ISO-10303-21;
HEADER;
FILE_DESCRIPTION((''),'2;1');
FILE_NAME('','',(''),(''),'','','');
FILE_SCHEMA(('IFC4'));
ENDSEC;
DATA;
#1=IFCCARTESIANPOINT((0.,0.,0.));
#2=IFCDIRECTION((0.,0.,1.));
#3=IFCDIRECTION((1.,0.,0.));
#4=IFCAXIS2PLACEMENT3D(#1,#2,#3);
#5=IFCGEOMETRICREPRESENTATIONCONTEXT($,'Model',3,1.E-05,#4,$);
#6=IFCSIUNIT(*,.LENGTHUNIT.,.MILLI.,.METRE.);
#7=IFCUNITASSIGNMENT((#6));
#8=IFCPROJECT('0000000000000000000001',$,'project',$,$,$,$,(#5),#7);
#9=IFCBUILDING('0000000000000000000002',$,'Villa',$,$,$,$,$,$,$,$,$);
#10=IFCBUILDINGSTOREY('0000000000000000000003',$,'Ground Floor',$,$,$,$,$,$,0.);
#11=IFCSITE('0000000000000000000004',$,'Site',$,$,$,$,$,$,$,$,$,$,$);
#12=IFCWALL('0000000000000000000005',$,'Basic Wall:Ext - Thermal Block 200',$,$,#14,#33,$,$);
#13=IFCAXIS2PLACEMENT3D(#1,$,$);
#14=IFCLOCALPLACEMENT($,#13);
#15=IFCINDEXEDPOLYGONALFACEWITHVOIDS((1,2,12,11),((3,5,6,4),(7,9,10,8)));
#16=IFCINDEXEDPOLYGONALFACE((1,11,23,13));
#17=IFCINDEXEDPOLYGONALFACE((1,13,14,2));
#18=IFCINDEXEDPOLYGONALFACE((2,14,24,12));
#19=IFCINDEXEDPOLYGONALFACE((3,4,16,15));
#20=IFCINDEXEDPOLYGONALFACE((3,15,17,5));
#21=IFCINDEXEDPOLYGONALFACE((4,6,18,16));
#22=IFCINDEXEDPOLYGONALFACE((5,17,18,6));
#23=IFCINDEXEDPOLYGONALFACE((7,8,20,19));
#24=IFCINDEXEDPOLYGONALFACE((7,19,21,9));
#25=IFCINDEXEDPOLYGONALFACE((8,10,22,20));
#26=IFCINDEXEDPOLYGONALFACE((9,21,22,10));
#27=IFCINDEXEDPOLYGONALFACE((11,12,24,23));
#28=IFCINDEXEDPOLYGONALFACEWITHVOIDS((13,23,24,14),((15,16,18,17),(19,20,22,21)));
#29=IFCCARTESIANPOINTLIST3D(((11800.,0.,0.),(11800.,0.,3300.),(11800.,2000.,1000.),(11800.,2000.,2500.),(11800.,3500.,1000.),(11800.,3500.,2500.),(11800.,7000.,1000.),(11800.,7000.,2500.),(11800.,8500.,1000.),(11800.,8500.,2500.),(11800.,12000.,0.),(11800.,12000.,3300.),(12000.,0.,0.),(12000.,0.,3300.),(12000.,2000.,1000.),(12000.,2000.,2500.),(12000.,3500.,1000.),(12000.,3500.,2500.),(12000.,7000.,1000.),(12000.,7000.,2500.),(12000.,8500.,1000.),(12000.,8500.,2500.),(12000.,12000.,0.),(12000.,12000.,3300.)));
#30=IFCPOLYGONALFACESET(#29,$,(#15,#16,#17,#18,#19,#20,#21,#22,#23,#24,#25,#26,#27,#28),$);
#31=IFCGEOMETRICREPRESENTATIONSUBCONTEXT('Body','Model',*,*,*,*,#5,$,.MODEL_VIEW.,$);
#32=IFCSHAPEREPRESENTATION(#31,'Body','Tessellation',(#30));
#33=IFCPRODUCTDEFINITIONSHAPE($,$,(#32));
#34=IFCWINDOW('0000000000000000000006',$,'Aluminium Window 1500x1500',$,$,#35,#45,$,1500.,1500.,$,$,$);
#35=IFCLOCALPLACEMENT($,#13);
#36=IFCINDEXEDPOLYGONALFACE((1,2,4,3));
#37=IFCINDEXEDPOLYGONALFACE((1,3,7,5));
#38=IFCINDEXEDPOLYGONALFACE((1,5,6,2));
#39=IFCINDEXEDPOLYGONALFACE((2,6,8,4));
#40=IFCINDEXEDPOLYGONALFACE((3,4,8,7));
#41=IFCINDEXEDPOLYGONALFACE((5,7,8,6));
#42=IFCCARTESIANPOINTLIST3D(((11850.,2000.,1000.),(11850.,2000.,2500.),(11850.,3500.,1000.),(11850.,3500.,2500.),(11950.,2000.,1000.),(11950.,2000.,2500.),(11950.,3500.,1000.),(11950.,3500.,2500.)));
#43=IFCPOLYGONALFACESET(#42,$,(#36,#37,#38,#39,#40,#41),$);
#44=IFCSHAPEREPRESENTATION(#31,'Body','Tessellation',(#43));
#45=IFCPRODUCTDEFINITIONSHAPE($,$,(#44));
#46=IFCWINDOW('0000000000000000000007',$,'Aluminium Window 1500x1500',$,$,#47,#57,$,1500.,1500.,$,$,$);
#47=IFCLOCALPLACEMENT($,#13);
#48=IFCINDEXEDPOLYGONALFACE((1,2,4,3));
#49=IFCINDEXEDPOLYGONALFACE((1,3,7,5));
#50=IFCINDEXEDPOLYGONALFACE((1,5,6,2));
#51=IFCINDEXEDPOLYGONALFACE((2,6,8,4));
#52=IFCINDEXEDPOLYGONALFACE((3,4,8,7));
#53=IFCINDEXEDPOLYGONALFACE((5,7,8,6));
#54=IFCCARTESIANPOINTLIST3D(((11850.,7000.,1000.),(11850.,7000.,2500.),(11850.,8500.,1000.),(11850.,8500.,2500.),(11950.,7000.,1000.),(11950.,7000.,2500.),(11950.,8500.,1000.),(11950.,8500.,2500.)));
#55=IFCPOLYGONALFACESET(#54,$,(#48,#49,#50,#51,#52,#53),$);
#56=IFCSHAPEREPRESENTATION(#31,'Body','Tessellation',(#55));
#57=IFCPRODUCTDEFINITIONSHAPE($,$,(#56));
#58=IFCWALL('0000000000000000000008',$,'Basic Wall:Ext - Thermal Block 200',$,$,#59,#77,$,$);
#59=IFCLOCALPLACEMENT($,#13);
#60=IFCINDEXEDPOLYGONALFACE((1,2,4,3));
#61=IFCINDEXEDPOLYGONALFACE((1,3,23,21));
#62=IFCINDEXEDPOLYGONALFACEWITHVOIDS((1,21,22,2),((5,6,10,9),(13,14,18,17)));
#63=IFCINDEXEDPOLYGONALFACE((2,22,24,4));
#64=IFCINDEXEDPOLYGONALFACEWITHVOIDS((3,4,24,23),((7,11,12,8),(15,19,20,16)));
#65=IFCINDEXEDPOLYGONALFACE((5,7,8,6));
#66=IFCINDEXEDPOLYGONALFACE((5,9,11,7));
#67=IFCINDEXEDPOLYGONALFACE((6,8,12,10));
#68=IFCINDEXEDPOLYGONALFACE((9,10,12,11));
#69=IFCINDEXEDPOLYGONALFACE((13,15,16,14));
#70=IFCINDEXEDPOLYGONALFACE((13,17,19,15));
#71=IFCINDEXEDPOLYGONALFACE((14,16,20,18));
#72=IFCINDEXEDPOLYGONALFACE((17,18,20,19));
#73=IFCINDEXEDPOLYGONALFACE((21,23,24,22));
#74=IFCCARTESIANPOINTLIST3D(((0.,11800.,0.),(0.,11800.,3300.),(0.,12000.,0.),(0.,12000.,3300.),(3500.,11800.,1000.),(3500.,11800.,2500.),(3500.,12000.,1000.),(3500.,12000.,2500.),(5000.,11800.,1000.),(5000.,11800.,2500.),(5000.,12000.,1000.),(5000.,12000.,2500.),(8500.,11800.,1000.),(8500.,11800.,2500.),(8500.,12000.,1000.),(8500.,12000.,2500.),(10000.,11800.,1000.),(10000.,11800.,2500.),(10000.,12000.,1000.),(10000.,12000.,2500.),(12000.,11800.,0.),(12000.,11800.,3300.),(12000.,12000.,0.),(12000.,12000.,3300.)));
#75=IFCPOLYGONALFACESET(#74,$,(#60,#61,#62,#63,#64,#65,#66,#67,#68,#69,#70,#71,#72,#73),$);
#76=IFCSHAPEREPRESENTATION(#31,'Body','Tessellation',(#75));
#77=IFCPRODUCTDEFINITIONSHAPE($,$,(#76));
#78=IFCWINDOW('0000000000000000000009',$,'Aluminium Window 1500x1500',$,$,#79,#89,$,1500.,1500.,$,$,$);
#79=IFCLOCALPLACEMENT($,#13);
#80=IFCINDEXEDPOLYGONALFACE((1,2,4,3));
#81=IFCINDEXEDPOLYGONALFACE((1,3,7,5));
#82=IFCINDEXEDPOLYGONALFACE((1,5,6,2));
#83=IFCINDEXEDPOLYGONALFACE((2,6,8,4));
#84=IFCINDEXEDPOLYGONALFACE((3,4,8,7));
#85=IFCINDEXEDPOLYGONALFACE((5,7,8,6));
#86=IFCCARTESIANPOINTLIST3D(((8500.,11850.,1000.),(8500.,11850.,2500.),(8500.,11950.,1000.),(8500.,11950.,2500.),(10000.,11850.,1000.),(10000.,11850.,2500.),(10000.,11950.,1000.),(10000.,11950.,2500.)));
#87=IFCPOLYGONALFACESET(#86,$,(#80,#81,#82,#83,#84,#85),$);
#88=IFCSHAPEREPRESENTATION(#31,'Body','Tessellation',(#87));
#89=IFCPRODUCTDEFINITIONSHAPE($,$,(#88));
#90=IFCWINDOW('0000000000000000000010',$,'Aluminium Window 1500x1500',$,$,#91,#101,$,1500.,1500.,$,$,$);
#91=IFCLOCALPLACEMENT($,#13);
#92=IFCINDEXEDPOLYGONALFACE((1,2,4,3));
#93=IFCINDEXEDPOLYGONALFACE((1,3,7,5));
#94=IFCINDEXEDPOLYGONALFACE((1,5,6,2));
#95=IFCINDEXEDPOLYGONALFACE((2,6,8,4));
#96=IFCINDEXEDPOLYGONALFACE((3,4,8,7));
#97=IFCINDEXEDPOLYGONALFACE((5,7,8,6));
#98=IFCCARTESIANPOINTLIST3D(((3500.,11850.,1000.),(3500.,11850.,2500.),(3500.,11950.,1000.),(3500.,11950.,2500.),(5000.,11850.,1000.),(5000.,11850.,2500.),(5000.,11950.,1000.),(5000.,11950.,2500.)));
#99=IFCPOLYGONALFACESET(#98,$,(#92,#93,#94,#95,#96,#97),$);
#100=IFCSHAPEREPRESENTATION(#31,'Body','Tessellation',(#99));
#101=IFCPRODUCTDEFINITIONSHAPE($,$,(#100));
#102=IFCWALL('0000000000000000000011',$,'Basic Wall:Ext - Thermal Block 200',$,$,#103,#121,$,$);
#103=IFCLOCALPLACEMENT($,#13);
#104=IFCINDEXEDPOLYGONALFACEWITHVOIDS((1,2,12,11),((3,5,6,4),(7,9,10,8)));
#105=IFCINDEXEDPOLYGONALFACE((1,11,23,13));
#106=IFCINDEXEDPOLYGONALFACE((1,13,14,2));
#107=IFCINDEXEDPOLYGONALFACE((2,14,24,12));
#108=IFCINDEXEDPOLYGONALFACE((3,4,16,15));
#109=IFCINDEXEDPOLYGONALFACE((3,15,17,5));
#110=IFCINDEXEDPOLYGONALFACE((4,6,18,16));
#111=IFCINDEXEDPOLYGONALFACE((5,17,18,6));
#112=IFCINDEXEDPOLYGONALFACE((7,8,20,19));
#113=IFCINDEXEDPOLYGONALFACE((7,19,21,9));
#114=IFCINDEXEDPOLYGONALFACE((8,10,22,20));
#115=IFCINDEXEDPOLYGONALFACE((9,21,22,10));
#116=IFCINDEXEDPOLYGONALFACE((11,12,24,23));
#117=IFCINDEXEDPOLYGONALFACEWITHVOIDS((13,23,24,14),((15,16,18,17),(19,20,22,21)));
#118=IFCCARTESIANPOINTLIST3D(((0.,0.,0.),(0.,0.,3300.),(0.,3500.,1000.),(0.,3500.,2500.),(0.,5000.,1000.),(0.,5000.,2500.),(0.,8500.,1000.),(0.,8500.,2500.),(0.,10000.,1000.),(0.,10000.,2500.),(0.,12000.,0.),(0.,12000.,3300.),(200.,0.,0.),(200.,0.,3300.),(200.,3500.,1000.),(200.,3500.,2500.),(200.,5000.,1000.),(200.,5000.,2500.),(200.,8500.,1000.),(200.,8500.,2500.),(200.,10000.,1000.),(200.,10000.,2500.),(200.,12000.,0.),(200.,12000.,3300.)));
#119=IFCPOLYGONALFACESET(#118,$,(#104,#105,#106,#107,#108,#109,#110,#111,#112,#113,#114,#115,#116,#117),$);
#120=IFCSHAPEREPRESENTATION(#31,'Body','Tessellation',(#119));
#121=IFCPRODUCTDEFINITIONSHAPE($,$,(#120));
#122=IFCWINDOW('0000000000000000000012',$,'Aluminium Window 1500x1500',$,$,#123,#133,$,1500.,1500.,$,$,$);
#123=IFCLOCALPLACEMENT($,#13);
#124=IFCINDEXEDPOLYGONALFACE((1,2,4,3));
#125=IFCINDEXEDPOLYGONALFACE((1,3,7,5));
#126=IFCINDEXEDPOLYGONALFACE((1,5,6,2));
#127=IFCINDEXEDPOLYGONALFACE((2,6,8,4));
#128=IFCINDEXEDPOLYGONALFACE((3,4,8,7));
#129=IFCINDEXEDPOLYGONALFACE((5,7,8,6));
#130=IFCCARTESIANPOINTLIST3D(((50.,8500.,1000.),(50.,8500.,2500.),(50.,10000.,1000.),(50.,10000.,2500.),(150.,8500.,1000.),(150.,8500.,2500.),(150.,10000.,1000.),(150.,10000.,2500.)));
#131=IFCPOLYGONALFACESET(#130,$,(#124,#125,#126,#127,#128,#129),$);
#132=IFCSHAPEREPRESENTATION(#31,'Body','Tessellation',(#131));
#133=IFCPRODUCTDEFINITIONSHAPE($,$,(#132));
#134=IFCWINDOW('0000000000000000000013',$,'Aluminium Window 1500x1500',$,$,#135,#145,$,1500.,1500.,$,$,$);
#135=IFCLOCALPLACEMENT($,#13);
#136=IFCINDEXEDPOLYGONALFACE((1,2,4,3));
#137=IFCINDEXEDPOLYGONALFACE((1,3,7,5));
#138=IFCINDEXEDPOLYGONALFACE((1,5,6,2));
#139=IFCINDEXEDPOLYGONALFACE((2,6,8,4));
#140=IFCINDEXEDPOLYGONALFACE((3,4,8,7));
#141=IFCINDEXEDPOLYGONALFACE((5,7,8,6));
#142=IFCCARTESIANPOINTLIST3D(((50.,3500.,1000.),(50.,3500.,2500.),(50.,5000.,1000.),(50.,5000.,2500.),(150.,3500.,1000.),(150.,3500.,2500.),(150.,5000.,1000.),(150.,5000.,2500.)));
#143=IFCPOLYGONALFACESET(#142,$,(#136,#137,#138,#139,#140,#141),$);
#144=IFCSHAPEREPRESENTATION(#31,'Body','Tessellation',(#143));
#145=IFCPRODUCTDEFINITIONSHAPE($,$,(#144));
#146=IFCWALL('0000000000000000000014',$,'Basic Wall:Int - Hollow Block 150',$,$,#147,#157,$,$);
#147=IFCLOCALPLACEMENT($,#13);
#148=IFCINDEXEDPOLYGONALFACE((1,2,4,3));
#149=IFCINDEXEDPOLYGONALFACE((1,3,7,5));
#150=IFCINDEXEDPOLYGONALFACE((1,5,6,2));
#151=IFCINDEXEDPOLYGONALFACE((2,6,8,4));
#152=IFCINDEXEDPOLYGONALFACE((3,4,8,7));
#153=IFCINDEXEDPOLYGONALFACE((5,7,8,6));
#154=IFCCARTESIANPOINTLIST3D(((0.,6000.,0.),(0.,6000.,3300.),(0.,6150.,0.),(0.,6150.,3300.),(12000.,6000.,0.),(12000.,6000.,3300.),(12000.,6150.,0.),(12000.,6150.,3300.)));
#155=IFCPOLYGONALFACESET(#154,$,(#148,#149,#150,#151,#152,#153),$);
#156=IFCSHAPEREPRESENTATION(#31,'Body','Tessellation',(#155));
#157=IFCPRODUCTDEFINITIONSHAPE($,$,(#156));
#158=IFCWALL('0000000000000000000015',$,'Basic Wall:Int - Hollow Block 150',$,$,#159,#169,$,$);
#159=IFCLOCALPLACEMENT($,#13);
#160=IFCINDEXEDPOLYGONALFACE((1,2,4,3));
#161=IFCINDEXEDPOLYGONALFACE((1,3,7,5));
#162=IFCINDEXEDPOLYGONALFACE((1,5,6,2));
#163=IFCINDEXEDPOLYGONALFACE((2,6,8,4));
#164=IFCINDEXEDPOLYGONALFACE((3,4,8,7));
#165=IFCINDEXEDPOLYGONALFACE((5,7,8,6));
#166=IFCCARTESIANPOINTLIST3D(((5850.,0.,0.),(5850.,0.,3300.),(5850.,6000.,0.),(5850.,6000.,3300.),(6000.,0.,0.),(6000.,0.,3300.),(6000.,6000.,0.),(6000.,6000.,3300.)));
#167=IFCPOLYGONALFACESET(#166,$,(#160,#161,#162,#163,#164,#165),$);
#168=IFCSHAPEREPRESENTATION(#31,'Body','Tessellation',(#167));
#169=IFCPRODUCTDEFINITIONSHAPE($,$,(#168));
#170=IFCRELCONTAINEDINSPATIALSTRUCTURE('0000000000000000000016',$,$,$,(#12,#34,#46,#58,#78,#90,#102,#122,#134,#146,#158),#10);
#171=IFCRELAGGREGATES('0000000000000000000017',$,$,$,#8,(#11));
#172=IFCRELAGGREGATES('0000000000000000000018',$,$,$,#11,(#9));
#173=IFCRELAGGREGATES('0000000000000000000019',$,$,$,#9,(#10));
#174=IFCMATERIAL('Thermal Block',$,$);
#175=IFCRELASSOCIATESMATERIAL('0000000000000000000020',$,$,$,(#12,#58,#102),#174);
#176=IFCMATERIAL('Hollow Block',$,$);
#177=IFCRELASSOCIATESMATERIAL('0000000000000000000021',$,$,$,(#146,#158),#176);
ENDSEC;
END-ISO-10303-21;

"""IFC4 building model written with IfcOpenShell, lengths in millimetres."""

from ifc_helpers import new_model, si_unit, frame, origin_with_axes, place, context, subcontext, project, spatial, indexed_curve, outline, extrude, material, element, fill, save


model = new_model("IFC4")

# Units and contexts
model_context = context("Model", 3, precision=1e-05, world=origin_with_axes())
body_context = subcontext(model_context, "Body", "Model", "MODEL_VIEW")
ifc_project = project(units=[si_unit("LENGTHUNIT", "METRE", prefix="MILLI")], contexts=[model_context])

# Site, building, storey
site = spatial("IfcSite", under=ifc_project, Name="Site")
building = spatial("IfcBuilding", under=site, Name="Villa")
storey = spatial("IfcBuildingStorey", under=building, Name="Ground Floor", Elevation=0.0)

# Shared definitions
ifc_material_1 = material(Name="Thermal Block")

# Walls, openings, windows
wall_1_placement = place(None, frame((12000.0, 0.0, 0.0), z_axis=(0.0, 0.0, 1.0), x_axis=(0.0, 1.0, 0.0)))
wall_1 = element("IfcWall", 1, at=wall_1_placement, inside=storey, material=ifc_material_1, Name="Basic Wall:Ext - Thermal Block 200", context=body_context, shape_type="SweptSolid", body=[
    extrude(outline(indexed_curve([(0.0, 0.0), (0.0, 200.0), (12000.0, 200.0), (12000.0, 0.0), (0.0, 0.0)], self_intersect=False)), origin_with_axes(), (0.0, 0.0, 1.0), 3300.0),
])
opening_1_placement = place(wall_1_placement, frame((2000.0, -200.0, 1000.0), z_axis=(0.0, 0.0, 1.0), x_axis=(1.0, 0.0, 0.0)))
opening_1 = element("IfcOpeningElement", 2, at=opening_1_placement, cuts=wall_1, context=body_context, shape_type="SweptSolid", body=[
    extrude(outline(indexed_curve([(0.0, 0.0), (0.0, 600.0), (1500.0, 600.0), (1500.0, 0.0), (0.0, 0.0)], self_intersect=False)), origin_with_axes(), (0.0, 0.0, 1.0), 1500.0),
])
opening_2_placement = place(wall_1_placement, frame((7000.0, -200.0, 1000.0), z_axis=(0.0, 0.0, 1.0), x_axis=(1.0, 0.0, 0.0)))
opening_2 = element("IfcOpeningElement", 3, at=opening_2_placement, cuts=wall_1, context=body_context, shape_type="SweptSolid", body=[
    extrude(outline(indexed_curve([(0.0, 0.0), (0.0, 600.0), (1500.0, 600.0), (1500.0, 0.0), (0.0, 0.0)], self_intersect=False)), origin_with_axes(), (0.0, 0.0, 1.0), 1500.0),
])
window_1_placement = place(None, frame((11950.0, 2000.0, 1000.0), z_axis=(0.0, 0.0, 1.0), x_axis=(0.0, 1.0, 0.0)))
window_1 = element("IfcWindow", 4, at=window_1_placement, inside=storey, Name="Aluminium Window 1500x1500", OverallHeight=1500.0, OverallWidth=1500.0, context=body_context, shape_type="SweptSolid", body=[
    extrude(outline(indexed_curve([(0.0, 0.0), (0.0, 100.0), (1500.0, 100.0), (1500.0, 0.0), (0.0, 0.0)], self_intersect=False)), origin_with_axes(), (0.0, 0.0, 1.0), 1500.0),
])
fill(opening_1, window_1)
window_2_placement = place(None, frame((11950.0, 7000.0, 1000.0), z_axis=(0.0, 0.0, 1.0), x_axis=(0.0, 1.0, 0.0)))
window_2 = element("IfcWindow", 5, at=window_2_placement, inside=storey, Name="Aluminium Window 1500x1500", OverallHeight=1500.0, OverallWidth=1500.0, context=body_context, shape_type="SweptSolid", body=[
    extrude(outline(indexed_curve([(0.0, 0.0), (0.0, 100.0), (1500.0, 100.0), (1500.0, 0.0), (0.0, 0.0)], self_intersect=False)), origin_with_axes(), (0.0, 0.0, 1.0), 1500.0),
])
fill(opening_2, window_2)
wall_2_placement = place(None, frame((12000.0, 12000.0, 0.0), z_axis=(0.0, 0.0, 1.0), x_axis=(-1.0, 0.0, 0.0)))
wall_2 = element("IfcWall", 6, at=wall_2_placement, inside=storey, material=ifc_material_1, Name="Basic Wall:Ext - Thermal Block 200", context=body_context, shape_type="SweptSolid", body=[
    extrude(outline(indexed_curve([(0.0, 0.0), (0.0, 200.0), (12000.0, 200.0), (12000.0, 0.0), (0.0, 0.0)], self_intersect=False)), origin_with_axes(), (0.0, 0.0, 1.0), 3300.0),
])
opening_3_placement = place(wall_2_placement, frame((2000.0, -200.0, 1000.0), z_axis=(0.0, 0.0, 1.0), x_axis=(1.0, 0.0, 0.0)))
opening_3 = element("IfcOpeningElement", 7, at=opening_3_placement, cuts=wall_2, context=body_context, shape_type="SweptSolid", body=[
    extrude(outline(indexed_curve([(0.0, 0.0), (0.0, 600.0), (1500.0, 600.0), (1500.0, 0.0), (0.0, 0.0)], self_intersect=False)), origin_with_axes(), (0.0, 0.0, 1.0), 1500.0),
])
opening_4_placement = place(wall_2_placement, frame((7000.0, -200.0, 1000.0), z_axis=(0.0, 0.0, 1.0), x_axis=(1.0, 0.0, 0.0)))
opening_4 = element("IfcOpeningElement", 8, at=opening_4_placement, cuts=wall_2, context=body_context, shape_type="SweptSolid", body=[
    extrude(outline(indexed_curve([(0.0, 0.0), (0.0, 600.0), (1500.0, 600.0), (1500.0, 0.0), (0.0, 0.0)], self_intersect=False)), origin_with_axes(), (0.0, 0.0, 1.0), 1500.0),
])
window_3_placement = place(None, frame((10000.0, 11950.0, 1000.0), z_axis=(0.0, 0.0, 1.0), x_axis=(-1.0, 0.0, 0.0)))
window_3 = element("IfcWindow", 9, at=window_3_placement, inside=storey, Name="Aluminium Window 1500x1500", OverallHeight=1500.0, OverallWidth=1500.0, context=body_context, shape_type="SweptSolid", body=[
    extrude(outline(indexed_curve([(0.0, 0.0), (0.0, 100.0), (1500.0, 100.0), (1500.0, 0.0), (0.0, 0.0)], self_intersect=False)), origin_with_axes(), (0.0, 0.0, 1.0), 1500.0),
])
fill(opening_3, window_3)
window_4_placement = place(None, frame((5000.0, 11950.0, 1000.0), z_axis=(0.0, 0.0, 1.0), x_axis=(-1.0, 0.0, 0.0)))
window_4 = element("IfcWindow", 10, at=window_4_placement, inside=storey, Name="Aluminium Window 1500x1500", OverallHeight=1500.0, OverallWidth=1500.0, context=body_context, shape_type="SweptSolid", body=[
    extrude(outline(indexed_curve([(0.0, 0.0), (0.0, 100.0), (1500.0, 100.0), (1500.0, 0.0), (0.0, 0.0)], self_intersect=False)), origin_with_axes(), (0.0, 0.0, 1.0), 1500.0),
])
fill(opening_4, window_4)
wall_3_placement = place(None, frame((0.0, 12000.0, 0.0), z_axis=(0.0, 0.0, 1.0), x_axis=(0.0, -1.0, 0.0)))
wall_3 = element("IfcWall", 11, at=wall_3_placement, inside=storey, material=ifc_material_1, Name="Basic Wall:Ext - Thermal Block 200", context=body_context, shape_type="SweptSolid", body=[
    extrude(outline(indexed_curve([(0.0, 0.0), (0.0, 200.0), (12000.0, 200.0), (12000.0, 0.0), (0.0, 0.0)], self_intersect=False)), origin_with_axes(), (0.0, 0.0, 1.0), 3300.0),
])
opening_5_placement = place(wall_3_placement, frame((2000.0, -200.0, 1000.0), z_axis=(0.0, 0.0, 1.0), x_axis=(1.0, 0.0, 0.0)))
opening_5 = element("IfcOpeningElement", 12, at=opening_5_placement, cuts=wall_3, context=body_context, shape_type="SweptSolid", body=[
    extrude(outline(indexed_curve([(0.0, 0.0), (0.0, 600.0), (1500.0, 600.0), (1500.0, 0.0), (0.0, 0.0)], self_intersect=False)), origin_with_axes(), (0.0, 0.0, 1.0), 1500.0),
])
opening_6_placement = place(wall_3_placement, frame((7000.0, -200.0, 1000.0), z_axis=(0.0, 0.0, 1.0), x_axis=(1.0, 0.0, 0.0)))
opening_6 = element("IfcOpeningElement", 13, at=opening_6_placement, cuts=wall_3, context=body_context, shape_type="SweptSolid", body=[
    extrude(outline(indexed_curve([(0.0, 0.0), (0.0, 600.0), (1500.0, 600.0), (1500.0, 0.0), (0.0, 0.0)], self_intersect=False)), origin_with_axes(), (0.0, 0.0, 1.0), 1500.0),
])
window_5_placement = place(None, frame((50.0, 10000.0, 1000.0), z_axis=(0.0, 0.0, 1.0), x_axis=(0.0, -1.0, 0.0)))
window_5 = element("IfcWindow", 14, at=window_5_placement, inside=storey, Name="Aluminium Window 1500x1500", OverallHeight=1500.0, OverallWidth=1500.0, context=body_context, shape_type="SweptSolid", body=[
    extrude(outline(indexed_curve([(0.0, 0.0), (0.0, 100.0), (1500.0, 100.0), (1500.0, 0.0), (0.0, 0.0)], self_intersect=False)), origin_with_axes(), (0.0, 0.0, 1.0), 1500.0),
])
fill(opening_5, window_5)
window_6_placement = place(None, frame((50.0, 5000.0, 1000.0), z_axis=(0.0, 0.0, 1.0), x_axis=(0.0, -1.0, 0.0)))
window_6 = element("IfcWindow", 15, at=window_6_placement, inside=storey, Name="Aluminium Window 1500x1500", OverallHeight=1500.0, OverallWidth=1500.0, context=body_context, shape_type="SweptSolid", body=[
    extrude(outline(indexed_curve([(0.0, 0.0), (0.0, 100.0), (1500.0, 100.0), (1500.0, 0.0), (0.0, 0.0)], self_intersect=False)), origin_with_axes(), (0.0, 0.0, 1.0), 1500.0),
])
fill(opening_6, window_6)

# Walls
ifc_material_2 = material(Name="Hollow Block")
wall_4_placement = place(None, frame((0.0, 6000.0, 0.0), z_axis=(0.0, 0.0, 1.0), x_axis=(1.0, 0.0, 0.0)))
element("IfcWall", 16, at=wall_4_placement, inside=storey, material=ifc_material_2, Name="Basic Wall:Int - Hollow Block 150", context=body_context, shape_type="SweptSolid", body=[
    extrude(outline(indexed_curve([(0.0, 0.0), (0.0, 150.0), (12000.0, 150.0), (12000.0, 0.0), (0.0, 0.0)], self_intersect=False)), origin_with_axes(), (0.0, 0.0, 1.0), 3300.0),
])
wall_5_placement = place(None, frame((6000.0, 0.0, 0.0), z_axis=(0.0, 0.0, 1.0), x_axis=(0.0, 1.0, 0.0)))
element("IfcWall", 17, at=wall_5_placement, inside=storey, material=ifc_material_2, Name="Basic Wall:Int - Hollow Block 150", context=body_context, shape_type="SweptSolid", body=[
    extrude(outline(indexed_curve([(0.0, 0.0), (0.0, 150.0), (6000.0, 150.0), (6000.0, 0.0), (0.0, 0.0)], self_intersect=False)), origin_with_axes(), (0.0, 0.0, 1.0), 3300.0),
])

save(model, "model.ifc")
